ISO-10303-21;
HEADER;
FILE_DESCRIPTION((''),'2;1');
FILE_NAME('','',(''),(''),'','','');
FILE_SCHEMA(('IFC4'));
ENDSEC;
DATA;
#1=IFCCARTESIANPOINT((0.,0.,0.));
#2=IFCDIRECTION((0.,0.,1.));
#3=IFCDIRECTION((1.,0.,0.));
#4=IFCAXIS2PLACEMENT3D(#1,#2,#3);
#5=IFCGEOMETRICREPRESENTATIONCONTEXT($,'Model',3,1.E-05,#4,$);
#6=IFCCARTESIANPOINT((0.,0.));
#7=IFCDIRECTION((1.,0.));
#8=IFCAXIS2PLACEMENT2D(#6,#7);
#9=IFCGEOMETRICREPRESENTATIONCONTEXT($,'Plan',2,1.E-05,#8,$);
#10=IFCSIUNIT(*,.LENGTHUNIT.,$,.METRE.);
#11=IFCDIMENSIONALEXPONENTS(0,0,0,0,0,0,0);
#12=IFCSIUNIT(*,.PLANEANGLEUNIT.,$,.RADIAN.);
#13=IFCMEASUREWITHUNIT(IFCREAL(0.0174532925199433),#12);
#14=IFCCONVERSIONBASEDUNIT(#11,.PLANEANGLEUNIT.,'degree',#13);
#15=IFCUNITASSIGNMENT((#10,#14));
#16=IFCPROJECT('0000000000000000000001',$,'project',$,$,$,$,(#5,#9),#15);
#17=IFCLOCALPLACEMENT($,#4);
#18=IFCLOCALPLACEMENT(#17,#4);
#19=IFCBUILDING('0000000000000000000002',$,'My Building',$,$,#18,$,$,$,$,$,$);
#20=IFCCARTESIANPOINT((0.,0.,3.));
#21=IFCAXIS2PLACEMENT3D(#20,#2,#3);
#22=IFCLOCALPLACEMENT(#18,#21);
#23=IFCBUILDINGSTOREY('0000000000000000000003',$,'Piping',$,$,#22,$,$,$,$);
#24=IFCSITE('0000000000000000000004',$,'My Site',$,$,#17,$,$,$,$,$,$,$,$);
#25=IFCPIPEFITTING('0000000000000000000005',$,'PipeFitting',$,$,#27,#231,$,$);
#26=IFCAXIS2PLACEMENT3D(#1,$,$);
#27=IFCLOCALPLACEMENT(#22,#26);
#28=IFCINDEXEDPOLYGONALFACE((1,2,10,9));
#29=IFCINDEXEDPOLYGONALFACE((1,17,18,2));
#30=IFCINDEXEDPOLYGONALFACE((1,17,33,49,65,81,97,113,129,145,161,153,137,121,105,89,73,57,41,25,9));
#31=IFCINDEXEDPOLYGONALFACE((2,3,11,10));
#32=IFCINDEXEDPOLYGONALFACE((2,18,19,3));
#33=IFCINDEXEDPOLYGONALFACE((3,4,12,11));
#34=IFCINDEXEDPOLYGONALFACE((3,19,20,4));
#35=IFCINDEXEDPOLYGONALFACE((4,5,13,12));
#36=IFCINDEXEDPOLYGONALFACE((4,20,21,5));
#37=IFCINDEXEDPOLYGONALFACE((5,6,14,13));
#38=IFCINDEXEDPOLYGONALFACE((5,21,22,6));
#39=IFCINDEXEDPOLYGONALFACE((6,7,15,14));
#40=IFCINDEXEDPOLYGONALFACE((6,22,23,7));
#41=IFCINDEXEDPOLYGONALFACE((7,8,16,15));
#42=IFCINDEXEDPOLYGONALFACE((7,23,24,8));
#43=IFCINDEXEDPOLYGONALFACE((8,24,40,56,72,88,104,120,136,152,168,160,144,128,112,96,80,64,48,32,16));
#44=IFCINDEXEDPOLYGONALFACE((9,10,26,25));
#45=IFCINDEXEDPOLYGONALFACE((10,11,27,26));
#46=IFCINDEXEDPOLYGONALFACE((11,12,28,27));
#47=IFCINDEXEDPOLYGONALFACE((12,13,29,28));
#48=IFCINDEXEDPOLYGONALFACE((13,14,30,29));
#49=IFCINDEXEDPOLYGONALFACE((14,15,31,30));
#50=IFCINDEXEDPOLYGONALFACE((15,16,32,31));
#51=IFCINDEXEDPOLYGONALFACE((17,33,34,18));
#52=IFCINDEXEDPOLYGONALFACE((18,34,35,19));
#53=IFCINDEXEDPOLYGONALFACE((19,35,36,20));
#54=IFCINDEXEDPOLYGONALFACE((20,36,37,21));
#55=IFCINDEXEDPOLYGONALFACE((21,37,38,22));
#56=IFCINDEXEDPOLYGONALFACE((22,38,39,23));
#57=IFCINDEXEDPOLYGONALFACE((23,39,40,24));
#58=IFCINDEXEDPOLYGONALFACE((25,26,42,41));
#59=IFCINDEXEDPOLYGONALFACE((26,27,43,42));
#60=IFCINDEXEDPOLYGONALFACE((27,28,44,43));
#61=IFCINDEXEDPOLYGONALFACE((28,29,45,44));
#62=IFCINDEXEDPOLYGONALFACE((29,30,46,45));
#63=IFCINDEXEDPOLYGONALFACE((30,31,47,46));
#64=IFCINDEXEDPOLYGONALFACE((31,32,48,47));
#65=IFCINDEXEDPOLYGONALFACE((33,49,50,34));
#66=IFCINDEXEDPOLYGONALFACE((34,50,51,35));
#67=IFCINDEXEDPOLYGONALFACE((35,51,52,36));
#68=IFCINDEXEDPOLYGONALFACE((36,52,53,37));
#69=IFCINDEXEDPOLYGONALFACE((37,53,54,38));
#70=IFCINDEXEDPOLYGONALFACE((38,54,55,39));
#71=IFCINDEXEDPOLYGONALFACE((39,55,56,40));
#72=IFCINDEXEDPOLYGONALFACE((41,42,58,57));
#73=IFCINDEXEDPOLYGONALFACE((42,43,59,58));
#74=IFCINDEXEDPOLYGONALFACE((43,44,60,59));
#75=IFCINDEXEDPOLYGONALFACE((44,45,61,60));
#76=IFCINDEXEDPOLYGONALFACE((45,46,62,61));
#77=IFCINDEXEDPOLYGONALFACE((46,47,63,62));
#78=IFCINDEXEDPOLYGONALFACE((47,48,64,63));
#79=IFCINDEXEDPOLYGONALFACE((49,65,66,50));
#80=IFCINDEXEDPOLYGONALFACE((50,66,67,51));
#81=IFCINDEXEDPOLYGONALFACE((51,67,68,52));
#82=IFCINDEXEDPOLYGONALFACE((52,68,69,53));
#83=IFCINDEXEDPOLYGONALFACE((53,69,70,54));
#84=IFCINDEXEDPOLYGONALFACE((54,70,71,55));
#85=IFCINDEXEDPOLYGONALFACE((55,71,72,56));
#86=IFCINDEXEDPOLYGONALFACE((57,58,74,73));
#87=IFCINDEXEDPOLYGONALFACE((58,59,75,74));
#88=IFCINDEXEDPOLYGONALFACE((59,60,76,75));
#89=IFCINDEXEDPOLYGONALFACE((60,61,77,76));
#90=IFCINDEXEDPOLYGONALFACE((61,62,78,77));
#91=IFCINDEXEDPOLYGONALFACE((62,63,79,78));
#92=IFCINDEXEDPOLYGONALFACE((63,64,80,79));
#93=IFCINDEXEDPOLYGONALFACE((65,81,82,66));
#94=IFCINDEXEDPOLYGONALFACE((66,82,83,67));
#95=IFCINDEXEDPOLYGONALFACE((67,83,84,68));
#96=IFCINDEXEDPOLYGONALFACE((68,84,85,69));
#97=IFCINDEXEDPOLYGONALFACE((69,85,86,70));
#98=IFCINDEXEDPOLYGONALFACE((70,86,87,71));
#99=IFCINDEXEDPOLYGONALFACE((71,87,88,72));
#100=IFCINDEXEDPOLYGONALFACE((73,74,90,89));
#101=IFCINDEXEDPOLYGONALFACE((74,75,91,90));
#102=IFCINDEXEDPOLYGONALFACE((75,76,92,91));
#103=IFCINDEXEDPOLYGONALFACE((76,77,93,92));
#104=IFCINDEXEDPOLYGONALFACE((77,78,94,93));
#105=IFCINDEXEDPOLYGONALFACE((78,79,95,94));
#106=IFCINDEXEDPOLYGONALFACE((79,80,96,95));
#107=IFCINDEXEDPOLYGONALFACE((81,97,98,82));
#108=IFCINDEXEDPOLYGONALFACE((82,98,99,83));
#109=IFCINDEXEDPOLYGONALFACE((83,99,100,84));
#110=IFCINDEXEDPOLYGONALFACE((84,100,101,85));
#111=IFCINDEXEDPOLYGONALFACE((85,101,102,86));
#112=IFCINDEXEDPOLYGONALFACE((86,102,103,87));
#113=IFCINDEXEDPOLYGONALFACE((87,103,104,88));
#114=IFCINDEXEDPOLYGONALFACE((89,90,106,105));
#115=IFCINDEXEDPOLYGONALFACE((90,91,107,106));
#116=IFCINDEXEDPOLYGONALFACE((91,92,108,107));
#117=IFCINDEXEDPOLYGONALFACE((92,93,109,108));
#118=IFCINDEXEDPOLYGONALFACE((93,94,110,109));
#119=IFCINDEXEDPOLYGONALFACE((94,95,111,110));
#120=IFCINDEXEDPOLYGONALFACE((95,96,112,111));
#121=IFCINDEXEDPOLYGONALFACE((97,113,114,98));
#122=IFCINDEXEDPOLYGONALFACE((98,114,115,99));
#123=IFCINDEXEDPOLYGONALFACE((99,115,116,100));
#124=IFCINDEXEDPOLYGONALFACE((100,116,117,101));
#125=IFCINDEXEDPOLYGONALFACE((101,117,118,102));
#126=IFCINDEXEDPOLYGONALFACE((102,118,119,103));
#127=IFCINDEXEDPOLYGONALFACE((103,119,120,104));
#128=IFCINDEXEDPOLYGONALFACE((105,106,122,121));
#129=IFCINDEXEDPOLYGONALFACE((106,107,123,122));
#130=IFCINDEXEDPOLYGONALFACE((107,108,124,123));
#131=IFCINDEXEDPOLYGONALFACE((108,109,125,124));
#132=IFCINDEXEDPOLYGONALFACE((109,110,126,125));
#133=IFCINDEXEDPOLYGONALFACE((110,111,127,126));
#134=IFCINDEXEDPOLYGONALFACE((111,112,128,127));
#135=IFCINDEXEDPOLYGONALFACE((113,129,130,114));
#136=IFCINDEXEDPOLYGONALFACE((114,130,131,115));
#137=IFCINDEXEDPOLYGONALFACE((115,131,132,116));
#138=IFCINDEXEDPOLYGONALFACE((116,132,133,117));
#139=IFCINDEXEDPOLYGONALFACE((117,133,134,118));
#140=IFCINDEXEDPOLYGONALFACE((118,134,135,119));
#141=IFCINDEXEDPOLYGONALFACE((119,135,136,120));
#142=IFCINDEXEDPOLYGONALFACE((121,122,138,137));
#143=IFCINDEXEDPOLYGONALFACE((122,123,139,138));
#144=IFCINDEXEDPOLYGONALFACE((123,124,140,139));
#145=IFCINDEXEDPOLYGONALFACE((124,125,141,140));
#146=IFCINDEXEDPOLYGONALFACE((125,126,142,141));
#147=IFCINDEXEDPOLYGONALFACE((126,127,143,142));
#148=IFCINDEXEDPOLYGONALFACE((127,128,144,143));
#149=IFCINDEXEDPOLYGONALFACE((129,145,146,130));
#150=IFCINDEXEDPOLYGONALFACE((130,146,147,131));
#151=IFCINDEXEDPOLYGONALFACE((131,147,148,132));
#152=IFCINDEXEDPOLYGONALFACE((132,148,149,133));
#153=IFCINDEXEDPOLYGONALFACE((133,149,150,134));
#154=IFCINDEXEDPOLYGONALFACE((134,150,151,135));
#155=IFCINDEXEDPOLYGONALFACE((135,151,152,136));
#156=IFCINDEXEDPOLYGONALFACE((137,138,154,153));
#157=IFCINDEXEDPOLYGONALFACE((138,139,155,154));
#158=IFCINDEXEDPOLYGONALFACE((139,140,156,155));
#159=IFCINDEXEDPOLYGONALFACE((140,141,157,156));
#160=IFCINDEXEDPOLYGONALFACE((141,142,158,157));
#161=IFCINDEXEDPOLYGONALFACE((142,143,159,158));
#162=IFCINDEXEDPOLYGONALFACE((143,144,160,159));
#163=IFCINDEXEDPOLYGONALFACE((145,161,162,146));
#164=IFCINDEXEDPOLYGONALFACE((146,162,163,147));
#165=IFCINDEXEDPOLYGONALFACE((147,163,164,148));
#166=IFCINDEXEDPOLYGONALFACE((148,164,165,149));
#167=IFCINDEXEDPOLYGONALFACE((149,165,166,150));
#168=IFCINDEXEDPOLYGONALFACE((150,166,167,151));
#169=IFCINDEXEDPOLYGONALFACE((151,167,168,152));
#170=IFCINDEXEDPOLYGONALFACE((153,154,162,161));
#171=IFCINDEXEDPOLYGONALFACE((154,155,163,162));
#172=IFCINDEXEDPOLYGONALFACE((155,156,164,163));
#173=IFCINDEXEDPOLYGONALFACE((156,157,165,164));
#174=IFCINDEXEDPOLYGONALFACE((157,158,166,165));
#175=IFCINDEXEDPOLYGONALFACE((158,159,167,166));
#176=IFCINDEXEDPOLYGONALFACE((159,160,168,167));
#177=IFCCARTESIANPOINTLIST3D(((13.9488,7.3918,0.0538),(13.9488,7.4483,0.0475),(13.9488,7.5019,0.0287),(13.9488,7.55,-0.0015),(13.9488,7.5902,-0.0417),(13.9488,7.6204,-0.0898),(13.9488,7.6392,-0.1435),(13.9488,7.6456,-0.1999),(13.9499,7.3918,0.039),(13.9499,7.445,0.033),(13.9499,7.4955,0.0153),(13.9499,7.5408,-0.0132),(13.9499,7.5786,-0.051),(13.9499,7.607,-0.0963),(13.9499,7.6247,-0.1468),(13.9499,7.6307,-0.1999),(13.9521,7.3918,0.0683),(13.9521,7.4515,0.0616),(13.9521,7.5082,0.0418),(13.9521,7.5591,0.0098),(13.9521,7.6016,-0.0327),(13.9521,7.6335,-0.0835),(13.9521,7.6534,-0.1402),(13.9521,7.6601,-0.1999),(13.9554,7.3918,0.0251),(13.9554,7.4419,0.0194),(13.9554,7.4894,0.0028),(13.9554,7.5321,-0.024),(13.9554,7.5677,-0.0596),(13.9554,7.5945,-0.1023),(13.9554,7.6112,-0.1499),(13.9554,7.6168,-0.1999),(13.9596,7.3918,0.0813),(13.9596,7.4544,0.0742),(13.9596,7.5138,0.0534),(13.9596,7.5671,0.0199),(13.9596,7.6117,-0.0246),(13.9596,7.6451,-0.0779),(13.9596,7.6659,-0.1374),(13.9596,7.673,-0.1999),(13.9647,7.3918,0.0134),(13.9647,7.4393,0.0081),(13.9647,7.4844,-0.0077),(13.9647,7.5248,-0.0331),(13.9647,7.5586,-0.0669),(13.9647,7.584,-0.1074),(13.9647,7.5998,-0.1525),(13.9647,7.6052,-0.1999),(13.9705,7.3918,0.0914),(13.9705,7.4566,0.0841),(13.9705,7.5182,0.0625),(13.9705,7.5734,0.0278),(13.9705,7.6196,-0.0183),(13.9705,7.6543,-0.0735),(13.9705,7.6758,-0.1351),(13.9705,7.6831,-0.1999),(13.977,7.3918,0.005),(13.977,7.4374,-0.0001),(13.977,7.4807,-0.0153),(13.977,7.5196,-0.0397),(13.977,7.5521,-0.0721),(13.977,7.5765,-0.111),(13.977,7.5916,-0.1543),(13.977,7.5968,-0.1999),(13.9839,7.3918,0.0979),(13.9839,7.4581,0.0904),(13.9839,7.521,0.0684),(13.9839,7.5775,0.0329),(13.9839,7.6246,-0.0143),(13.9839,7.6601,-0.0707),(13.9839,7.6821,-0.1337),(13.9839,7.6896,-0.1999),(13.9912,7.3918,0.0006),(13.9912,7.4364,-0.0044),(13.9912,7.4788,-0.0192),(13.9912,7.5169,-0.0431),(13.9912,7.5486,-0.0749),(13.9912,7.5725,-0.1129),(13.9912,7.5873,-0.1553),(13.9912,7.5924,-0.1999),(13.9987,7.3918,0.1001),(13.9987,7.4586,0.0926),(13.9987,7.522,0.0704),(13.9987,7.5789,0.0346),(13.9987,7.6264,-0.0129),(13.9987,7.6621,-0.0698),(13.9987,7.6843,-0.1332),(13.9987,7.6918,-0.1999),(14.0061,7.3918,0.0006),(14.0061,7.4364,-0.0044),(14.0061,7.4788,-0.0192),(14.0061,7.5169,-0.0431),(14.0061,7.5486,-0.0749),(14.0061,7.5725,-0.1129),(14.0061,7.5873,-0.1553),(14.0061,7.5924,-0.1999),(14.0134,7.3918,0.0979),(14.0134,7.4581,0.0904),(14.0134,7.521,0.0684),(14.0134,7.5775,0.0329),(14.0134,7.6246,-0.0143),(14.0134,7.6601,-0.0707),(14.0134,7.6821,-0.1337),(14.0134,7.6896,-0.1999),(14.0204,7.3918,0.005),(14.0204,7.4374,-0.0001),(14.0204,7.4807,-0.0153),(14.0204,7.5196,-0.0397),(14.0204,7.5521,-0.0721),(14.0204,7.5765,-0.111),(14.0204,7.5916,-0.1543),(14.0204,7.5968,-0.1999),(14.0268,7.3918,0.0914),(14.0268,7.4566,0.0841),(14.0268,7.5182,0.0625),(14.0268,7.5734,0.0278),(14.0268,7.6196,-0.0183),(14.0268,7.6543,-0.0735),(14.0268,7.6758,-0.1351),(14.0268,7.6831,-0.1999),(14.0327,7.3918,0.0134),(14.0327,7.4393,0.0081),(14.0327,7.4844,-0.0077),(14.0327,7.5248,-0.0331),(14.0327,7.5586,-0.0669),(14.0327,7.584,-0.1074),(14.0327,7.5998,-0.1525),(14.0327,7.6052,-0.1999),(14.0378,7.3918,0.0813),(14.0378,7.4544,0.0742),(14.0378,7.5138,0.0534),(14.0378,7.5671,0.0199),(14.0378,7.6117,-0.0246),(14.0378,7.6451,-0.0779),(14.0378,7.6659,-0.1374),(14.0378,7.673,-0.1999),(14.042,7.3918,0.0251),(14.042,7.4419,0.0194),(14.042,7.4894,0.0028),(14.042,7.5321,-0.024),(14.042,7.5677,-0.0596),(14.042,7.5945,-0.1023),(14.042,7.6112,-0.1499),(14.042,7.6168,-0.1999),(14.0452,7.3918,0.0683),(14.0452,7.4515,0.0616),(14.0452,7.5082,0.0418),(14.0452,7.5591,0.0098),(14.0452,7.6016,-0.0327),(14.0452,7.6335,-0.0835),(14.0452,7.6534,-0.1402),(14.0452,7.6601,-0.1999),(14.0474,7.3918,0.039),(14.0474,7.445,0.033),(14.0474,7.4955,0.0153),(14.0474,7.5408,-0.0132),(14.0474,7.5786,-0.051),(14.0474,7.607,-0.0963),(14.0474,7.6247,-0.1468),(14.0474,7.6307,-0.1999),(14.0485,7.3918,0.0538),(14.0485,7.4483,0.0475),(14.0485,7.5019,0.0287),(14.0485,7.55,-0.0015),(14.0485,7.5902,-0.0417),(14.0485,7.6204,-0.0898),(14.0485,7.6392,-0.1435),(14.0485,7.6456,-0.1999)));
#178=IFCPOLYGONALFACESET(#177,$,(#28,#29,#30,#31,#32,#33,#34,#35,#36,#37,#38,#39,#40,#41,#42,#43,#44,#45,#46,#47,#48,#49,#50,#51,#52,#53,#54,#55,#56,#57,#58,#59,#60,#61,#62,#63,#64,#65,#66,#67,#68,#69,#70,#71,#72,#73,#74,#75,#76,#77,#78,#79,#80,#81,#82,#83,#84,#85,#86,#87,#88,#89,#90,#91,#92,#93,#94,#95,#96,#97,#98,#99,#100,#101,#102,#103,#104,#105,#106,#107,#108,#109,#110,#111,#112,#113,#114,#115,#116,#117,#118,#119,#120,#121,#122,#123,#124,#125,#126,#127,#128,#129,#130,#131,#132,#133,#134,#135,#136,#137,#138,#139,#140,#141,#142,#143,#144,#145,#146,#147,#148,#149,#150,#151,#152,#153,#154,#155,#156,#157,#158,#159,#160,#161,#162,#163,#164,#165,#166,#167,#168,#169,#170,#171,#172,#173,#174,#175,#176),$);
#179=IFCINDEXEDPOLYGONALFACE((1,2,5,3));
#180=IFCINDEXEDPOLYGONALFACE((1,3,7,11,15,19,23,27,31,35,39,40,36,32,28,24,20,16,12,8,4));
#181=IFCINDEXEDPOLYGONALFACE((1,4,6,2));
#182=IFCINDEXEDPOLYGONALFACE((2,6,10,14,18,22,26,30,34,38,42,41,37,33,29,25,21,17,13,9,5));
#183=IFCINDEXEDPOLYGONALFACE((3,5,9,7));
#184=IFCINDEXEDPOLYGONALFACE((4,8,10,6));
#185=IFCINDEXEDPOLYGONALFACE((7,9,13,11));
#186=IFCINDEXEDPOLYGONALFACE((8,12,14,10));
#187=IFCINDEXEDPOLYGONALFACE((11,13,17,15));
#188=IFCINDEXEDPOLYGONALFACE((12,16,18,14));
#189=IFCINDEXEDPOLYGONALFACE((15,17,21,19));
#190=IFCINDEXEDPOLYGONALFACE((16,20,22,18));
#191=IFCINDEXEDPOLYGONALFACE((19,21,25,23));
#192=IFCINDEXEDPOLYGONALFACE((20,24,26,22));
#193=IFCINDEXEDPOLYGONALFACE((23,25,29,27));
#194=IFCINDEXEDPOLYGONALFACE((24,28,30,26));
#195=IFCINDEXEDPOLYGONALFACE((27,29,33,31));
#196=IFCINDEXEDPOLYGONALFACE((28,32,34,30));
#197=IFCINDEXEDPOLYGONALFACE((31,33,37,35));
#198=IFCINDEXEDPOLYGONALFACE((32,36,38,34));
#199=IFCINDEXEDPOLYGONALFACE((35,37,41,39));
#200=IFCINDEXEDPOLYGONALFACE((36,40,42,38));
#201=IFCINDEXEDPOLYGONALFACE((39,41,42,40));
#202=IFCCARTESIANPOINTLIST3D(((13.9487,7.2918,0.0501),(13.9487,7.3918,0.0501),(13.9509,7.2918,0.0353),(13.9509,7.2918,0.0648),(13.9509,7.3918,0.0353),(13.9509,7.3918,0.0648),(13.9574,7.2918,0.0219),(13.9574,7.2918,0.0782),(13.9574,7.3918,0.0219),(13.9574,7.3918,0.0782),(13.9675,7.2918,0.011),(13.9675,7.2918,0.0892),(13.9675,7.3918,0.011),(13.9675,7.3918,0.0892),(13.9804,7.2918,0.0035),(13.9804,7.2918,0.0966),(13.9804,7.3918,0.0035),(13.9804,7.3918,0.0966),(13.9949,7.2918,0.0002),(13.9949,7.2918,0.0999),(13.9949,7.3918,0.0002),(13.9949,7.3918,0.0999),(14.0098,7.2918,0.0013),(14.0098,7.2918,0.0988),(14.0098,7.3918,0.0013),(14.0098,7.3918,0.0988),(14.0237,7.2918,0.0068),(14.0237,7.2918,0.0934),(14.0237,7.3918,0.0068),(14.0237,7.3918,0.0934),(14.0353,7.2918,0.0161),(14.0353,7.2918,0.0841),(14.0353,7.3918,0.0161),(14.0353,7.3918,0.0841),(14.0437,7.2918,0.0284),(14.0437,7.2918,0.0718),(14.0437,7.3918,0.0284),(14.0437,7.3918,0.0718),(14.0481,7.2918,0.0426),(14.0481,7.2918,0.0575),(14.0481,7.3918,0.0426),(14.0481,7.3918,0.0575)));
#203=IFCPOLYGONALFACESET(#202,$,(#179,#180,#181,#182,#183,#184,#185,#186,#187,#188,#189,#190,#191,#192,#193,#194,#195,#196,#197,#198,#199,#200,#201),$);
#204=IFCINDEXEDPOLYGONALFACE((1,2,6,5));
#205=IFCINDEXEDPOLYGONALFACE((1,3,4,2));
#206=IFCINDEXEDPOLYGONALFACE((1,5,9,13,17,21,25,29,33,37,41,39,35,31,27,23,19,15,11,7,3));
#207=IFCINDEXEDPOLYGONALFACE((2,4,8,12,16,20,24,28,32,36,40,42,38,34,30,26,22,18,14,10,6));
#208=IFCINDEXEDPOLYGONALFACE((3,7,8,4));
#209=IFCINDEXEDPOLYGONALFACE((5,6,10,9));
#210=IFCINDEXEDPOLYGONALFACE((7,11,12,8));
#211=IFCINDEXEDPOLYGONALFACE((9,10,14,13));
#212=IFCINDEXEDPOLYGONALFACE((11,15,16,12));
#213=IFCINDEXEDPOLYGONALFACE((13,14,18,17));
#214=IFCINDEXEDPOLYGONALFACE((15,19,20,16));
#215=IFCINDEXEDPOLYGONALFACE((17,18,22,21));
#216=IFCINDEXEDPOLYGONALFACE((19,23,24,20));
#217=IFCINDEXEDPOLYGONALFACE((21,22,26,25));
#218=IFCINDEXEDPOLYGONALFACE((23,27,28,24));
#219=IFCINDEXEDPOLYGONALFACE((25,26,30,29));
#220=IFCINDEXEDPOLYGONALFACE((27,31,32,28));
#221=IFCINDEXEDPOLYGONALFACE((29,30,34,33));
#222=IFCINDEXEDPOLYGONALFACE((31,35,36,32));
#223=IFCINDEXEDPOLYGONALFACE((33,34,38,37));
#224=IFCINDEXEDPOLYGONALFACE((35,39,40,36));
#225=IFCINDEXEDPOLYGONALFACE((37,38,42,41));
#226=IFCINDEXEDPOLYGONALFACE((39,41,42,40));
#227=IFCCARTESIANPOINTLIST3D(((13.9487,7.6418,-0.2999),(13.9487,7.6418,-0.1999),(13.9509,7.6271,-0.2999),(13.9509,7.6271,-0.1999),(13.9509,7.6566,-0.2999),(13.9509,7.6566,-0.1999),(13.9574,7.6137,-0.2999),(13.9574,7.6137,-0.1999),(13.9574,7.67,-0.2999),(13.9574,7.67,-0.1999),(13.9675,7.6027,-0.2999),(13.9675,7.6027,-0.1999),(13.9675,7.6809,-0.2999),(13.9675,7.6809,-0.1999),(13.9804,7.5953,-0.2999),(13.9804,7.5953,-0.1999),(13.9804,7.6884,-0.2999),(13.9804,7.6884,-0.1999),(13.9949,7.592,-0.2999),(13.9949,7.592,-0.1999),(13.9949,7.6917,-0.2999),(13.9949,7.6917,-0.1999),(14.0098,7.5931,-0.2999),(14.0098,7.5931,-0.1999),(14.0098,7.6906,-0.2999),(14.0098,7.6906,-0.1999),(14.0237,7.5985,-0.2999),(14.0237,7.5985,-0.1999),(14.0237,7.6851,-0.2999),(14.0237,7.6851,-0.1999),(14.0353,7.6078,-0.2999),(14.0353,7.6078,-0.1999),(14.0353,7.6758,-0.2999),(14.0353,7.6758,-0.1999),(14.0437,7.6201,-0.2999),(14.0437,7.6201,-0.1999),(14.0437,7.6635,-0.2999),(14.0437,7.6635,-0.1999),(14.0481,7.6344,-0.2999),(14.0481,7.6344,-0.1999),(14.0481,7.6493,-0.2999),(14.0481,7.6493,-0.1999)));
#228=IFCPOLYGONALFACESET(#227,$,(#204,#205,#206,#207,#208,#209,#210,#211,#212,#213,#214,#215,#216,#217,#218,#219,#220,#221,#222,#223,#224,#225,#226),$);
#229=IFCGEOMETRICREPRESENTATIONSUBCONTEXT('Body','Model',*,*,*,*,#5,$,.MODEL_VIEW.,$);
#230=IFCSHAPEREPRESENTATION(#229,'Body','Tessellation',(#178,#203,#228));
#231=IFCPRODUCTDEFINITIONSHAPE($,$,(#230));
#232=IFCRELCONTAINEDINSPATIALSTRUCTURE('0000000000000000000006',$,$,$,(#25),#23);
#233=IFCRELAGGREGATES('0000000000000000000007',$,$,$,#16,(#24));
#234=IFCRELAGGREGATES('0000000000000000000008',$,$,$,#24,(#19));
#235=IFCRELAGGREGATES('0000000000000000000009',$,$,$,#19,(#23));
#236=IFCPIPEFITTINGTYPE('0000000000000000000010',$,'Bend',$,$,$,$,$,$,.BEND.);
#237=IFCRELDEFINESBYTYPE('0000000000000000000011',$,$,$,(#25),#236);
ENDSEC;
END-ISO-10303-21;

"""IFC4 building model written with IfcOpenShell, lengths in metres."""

from ifc_helpers import new_model, entity, si_unit, converted_unit, frame, origin_with_axes, origin_2d_with_axis, place, context, subcontext, project, spatial, circle, extrude, source, transform, mapped, type_object, type_shapes, element, save


model = new_model("IFC4")

# Units and contexts
model_context = context("Model", 3, precision=1e-05, world=origin_with_axes())
plan_context = context("Plan", 2, precision=1e-05, world=origin_2d_with_axis())
body_context = subcontext(model_context, "Body", "Model", "MODEL_VIEW")
ifc_project = project(units=[si_unit("LENGTHUNIT", "METRE"), converted_unit("PLANEANGLEUNIT", "degree", entity("IfcReal", 0.0174532925199433), si_unit("PLANEANGLEUNIT", "RADIAN"), dimensions=[0, 0, 0, 0, 0, 0, 0])], contexts=[model_context, plan_context])

# Site, building, storey
site_placement = place(None, origin_with_axes())
site = spatial("IfcSite", under=ifc_project, at=site_placement, Name="My Site")
building_placement = place(site_placement, origin_with_axes())
building = spatial("IfcBuilding", under=site, at=building_placement, Name="My Building")
storey_placement = place(building_placement, frame((0.0, 0.0, 3.0), z_axis=(0.0, 0.0, 1.0), x_axis=(1.0, 0.0, 0.0)))
storey = spatial("IfcBuildingStorey", under=building, at=storey_placement, Name="Piping")

# Pipe fitting
pipe_fitting_type_1 = type_object("IfcPipeFittingType", Name="Bend", PredefinedType="BEND")
shared_shape = source(origin_with_axes(), body_context, "Body", "SolidModel", [
    entity("IfcSweptDiskSolid", entity("IfcIndexedPolyCurve", entity("IfcCartesianPointList3D", [[0.0, 0.0, 0.1], [0.0, -0.0732, 0.2768], [0.0, -0.25, 0.35]]), [entity("IfcArcIndex", [1, 2, 3])]), 0.05),
    extrude(circle(Radius=0.05), origin_with_axes(), (0.0, 0.0, 1.0), 0.1),
    extrude(circle(Radius=0.05), frame((0.0, -0.25, 0.35), z_axis=(0.0, -1.0, -0.000003), x_axis=(1.0, 0.0, 0.0)), (0.0, 0.0, 1.0), 0.1),
])
type_shapes(pipe_fitting_type_1, [shared_shape])
for number, where, z_axis, x_axis, name in (
    (1, (13.9987, 7.2918, 0.0501), (0.0, 1.0, 0.0), (-1.0, 0.0, 0.0), "PipeFitting"),
):
    element("IfcPipeFitting", number, at=place(storey_placement, frame(where, z_axis=z_axis, x_axis=x_axis)), inside=storey, type_object=pipe_fitting_type_1, Name=name, context=body_context, shape_type="MappedRepresentation", body=[
        mapped(shared_shape, transform((0.0, 0.0, 0.0), x_axis=(1.0, 0.0, 0.0), y_axis=(0.0, 1.0, 0.0), z_axis=(0.0, 0.0, 1.0), scale=1.0)),
    ])

save(model, "model.ifc")
